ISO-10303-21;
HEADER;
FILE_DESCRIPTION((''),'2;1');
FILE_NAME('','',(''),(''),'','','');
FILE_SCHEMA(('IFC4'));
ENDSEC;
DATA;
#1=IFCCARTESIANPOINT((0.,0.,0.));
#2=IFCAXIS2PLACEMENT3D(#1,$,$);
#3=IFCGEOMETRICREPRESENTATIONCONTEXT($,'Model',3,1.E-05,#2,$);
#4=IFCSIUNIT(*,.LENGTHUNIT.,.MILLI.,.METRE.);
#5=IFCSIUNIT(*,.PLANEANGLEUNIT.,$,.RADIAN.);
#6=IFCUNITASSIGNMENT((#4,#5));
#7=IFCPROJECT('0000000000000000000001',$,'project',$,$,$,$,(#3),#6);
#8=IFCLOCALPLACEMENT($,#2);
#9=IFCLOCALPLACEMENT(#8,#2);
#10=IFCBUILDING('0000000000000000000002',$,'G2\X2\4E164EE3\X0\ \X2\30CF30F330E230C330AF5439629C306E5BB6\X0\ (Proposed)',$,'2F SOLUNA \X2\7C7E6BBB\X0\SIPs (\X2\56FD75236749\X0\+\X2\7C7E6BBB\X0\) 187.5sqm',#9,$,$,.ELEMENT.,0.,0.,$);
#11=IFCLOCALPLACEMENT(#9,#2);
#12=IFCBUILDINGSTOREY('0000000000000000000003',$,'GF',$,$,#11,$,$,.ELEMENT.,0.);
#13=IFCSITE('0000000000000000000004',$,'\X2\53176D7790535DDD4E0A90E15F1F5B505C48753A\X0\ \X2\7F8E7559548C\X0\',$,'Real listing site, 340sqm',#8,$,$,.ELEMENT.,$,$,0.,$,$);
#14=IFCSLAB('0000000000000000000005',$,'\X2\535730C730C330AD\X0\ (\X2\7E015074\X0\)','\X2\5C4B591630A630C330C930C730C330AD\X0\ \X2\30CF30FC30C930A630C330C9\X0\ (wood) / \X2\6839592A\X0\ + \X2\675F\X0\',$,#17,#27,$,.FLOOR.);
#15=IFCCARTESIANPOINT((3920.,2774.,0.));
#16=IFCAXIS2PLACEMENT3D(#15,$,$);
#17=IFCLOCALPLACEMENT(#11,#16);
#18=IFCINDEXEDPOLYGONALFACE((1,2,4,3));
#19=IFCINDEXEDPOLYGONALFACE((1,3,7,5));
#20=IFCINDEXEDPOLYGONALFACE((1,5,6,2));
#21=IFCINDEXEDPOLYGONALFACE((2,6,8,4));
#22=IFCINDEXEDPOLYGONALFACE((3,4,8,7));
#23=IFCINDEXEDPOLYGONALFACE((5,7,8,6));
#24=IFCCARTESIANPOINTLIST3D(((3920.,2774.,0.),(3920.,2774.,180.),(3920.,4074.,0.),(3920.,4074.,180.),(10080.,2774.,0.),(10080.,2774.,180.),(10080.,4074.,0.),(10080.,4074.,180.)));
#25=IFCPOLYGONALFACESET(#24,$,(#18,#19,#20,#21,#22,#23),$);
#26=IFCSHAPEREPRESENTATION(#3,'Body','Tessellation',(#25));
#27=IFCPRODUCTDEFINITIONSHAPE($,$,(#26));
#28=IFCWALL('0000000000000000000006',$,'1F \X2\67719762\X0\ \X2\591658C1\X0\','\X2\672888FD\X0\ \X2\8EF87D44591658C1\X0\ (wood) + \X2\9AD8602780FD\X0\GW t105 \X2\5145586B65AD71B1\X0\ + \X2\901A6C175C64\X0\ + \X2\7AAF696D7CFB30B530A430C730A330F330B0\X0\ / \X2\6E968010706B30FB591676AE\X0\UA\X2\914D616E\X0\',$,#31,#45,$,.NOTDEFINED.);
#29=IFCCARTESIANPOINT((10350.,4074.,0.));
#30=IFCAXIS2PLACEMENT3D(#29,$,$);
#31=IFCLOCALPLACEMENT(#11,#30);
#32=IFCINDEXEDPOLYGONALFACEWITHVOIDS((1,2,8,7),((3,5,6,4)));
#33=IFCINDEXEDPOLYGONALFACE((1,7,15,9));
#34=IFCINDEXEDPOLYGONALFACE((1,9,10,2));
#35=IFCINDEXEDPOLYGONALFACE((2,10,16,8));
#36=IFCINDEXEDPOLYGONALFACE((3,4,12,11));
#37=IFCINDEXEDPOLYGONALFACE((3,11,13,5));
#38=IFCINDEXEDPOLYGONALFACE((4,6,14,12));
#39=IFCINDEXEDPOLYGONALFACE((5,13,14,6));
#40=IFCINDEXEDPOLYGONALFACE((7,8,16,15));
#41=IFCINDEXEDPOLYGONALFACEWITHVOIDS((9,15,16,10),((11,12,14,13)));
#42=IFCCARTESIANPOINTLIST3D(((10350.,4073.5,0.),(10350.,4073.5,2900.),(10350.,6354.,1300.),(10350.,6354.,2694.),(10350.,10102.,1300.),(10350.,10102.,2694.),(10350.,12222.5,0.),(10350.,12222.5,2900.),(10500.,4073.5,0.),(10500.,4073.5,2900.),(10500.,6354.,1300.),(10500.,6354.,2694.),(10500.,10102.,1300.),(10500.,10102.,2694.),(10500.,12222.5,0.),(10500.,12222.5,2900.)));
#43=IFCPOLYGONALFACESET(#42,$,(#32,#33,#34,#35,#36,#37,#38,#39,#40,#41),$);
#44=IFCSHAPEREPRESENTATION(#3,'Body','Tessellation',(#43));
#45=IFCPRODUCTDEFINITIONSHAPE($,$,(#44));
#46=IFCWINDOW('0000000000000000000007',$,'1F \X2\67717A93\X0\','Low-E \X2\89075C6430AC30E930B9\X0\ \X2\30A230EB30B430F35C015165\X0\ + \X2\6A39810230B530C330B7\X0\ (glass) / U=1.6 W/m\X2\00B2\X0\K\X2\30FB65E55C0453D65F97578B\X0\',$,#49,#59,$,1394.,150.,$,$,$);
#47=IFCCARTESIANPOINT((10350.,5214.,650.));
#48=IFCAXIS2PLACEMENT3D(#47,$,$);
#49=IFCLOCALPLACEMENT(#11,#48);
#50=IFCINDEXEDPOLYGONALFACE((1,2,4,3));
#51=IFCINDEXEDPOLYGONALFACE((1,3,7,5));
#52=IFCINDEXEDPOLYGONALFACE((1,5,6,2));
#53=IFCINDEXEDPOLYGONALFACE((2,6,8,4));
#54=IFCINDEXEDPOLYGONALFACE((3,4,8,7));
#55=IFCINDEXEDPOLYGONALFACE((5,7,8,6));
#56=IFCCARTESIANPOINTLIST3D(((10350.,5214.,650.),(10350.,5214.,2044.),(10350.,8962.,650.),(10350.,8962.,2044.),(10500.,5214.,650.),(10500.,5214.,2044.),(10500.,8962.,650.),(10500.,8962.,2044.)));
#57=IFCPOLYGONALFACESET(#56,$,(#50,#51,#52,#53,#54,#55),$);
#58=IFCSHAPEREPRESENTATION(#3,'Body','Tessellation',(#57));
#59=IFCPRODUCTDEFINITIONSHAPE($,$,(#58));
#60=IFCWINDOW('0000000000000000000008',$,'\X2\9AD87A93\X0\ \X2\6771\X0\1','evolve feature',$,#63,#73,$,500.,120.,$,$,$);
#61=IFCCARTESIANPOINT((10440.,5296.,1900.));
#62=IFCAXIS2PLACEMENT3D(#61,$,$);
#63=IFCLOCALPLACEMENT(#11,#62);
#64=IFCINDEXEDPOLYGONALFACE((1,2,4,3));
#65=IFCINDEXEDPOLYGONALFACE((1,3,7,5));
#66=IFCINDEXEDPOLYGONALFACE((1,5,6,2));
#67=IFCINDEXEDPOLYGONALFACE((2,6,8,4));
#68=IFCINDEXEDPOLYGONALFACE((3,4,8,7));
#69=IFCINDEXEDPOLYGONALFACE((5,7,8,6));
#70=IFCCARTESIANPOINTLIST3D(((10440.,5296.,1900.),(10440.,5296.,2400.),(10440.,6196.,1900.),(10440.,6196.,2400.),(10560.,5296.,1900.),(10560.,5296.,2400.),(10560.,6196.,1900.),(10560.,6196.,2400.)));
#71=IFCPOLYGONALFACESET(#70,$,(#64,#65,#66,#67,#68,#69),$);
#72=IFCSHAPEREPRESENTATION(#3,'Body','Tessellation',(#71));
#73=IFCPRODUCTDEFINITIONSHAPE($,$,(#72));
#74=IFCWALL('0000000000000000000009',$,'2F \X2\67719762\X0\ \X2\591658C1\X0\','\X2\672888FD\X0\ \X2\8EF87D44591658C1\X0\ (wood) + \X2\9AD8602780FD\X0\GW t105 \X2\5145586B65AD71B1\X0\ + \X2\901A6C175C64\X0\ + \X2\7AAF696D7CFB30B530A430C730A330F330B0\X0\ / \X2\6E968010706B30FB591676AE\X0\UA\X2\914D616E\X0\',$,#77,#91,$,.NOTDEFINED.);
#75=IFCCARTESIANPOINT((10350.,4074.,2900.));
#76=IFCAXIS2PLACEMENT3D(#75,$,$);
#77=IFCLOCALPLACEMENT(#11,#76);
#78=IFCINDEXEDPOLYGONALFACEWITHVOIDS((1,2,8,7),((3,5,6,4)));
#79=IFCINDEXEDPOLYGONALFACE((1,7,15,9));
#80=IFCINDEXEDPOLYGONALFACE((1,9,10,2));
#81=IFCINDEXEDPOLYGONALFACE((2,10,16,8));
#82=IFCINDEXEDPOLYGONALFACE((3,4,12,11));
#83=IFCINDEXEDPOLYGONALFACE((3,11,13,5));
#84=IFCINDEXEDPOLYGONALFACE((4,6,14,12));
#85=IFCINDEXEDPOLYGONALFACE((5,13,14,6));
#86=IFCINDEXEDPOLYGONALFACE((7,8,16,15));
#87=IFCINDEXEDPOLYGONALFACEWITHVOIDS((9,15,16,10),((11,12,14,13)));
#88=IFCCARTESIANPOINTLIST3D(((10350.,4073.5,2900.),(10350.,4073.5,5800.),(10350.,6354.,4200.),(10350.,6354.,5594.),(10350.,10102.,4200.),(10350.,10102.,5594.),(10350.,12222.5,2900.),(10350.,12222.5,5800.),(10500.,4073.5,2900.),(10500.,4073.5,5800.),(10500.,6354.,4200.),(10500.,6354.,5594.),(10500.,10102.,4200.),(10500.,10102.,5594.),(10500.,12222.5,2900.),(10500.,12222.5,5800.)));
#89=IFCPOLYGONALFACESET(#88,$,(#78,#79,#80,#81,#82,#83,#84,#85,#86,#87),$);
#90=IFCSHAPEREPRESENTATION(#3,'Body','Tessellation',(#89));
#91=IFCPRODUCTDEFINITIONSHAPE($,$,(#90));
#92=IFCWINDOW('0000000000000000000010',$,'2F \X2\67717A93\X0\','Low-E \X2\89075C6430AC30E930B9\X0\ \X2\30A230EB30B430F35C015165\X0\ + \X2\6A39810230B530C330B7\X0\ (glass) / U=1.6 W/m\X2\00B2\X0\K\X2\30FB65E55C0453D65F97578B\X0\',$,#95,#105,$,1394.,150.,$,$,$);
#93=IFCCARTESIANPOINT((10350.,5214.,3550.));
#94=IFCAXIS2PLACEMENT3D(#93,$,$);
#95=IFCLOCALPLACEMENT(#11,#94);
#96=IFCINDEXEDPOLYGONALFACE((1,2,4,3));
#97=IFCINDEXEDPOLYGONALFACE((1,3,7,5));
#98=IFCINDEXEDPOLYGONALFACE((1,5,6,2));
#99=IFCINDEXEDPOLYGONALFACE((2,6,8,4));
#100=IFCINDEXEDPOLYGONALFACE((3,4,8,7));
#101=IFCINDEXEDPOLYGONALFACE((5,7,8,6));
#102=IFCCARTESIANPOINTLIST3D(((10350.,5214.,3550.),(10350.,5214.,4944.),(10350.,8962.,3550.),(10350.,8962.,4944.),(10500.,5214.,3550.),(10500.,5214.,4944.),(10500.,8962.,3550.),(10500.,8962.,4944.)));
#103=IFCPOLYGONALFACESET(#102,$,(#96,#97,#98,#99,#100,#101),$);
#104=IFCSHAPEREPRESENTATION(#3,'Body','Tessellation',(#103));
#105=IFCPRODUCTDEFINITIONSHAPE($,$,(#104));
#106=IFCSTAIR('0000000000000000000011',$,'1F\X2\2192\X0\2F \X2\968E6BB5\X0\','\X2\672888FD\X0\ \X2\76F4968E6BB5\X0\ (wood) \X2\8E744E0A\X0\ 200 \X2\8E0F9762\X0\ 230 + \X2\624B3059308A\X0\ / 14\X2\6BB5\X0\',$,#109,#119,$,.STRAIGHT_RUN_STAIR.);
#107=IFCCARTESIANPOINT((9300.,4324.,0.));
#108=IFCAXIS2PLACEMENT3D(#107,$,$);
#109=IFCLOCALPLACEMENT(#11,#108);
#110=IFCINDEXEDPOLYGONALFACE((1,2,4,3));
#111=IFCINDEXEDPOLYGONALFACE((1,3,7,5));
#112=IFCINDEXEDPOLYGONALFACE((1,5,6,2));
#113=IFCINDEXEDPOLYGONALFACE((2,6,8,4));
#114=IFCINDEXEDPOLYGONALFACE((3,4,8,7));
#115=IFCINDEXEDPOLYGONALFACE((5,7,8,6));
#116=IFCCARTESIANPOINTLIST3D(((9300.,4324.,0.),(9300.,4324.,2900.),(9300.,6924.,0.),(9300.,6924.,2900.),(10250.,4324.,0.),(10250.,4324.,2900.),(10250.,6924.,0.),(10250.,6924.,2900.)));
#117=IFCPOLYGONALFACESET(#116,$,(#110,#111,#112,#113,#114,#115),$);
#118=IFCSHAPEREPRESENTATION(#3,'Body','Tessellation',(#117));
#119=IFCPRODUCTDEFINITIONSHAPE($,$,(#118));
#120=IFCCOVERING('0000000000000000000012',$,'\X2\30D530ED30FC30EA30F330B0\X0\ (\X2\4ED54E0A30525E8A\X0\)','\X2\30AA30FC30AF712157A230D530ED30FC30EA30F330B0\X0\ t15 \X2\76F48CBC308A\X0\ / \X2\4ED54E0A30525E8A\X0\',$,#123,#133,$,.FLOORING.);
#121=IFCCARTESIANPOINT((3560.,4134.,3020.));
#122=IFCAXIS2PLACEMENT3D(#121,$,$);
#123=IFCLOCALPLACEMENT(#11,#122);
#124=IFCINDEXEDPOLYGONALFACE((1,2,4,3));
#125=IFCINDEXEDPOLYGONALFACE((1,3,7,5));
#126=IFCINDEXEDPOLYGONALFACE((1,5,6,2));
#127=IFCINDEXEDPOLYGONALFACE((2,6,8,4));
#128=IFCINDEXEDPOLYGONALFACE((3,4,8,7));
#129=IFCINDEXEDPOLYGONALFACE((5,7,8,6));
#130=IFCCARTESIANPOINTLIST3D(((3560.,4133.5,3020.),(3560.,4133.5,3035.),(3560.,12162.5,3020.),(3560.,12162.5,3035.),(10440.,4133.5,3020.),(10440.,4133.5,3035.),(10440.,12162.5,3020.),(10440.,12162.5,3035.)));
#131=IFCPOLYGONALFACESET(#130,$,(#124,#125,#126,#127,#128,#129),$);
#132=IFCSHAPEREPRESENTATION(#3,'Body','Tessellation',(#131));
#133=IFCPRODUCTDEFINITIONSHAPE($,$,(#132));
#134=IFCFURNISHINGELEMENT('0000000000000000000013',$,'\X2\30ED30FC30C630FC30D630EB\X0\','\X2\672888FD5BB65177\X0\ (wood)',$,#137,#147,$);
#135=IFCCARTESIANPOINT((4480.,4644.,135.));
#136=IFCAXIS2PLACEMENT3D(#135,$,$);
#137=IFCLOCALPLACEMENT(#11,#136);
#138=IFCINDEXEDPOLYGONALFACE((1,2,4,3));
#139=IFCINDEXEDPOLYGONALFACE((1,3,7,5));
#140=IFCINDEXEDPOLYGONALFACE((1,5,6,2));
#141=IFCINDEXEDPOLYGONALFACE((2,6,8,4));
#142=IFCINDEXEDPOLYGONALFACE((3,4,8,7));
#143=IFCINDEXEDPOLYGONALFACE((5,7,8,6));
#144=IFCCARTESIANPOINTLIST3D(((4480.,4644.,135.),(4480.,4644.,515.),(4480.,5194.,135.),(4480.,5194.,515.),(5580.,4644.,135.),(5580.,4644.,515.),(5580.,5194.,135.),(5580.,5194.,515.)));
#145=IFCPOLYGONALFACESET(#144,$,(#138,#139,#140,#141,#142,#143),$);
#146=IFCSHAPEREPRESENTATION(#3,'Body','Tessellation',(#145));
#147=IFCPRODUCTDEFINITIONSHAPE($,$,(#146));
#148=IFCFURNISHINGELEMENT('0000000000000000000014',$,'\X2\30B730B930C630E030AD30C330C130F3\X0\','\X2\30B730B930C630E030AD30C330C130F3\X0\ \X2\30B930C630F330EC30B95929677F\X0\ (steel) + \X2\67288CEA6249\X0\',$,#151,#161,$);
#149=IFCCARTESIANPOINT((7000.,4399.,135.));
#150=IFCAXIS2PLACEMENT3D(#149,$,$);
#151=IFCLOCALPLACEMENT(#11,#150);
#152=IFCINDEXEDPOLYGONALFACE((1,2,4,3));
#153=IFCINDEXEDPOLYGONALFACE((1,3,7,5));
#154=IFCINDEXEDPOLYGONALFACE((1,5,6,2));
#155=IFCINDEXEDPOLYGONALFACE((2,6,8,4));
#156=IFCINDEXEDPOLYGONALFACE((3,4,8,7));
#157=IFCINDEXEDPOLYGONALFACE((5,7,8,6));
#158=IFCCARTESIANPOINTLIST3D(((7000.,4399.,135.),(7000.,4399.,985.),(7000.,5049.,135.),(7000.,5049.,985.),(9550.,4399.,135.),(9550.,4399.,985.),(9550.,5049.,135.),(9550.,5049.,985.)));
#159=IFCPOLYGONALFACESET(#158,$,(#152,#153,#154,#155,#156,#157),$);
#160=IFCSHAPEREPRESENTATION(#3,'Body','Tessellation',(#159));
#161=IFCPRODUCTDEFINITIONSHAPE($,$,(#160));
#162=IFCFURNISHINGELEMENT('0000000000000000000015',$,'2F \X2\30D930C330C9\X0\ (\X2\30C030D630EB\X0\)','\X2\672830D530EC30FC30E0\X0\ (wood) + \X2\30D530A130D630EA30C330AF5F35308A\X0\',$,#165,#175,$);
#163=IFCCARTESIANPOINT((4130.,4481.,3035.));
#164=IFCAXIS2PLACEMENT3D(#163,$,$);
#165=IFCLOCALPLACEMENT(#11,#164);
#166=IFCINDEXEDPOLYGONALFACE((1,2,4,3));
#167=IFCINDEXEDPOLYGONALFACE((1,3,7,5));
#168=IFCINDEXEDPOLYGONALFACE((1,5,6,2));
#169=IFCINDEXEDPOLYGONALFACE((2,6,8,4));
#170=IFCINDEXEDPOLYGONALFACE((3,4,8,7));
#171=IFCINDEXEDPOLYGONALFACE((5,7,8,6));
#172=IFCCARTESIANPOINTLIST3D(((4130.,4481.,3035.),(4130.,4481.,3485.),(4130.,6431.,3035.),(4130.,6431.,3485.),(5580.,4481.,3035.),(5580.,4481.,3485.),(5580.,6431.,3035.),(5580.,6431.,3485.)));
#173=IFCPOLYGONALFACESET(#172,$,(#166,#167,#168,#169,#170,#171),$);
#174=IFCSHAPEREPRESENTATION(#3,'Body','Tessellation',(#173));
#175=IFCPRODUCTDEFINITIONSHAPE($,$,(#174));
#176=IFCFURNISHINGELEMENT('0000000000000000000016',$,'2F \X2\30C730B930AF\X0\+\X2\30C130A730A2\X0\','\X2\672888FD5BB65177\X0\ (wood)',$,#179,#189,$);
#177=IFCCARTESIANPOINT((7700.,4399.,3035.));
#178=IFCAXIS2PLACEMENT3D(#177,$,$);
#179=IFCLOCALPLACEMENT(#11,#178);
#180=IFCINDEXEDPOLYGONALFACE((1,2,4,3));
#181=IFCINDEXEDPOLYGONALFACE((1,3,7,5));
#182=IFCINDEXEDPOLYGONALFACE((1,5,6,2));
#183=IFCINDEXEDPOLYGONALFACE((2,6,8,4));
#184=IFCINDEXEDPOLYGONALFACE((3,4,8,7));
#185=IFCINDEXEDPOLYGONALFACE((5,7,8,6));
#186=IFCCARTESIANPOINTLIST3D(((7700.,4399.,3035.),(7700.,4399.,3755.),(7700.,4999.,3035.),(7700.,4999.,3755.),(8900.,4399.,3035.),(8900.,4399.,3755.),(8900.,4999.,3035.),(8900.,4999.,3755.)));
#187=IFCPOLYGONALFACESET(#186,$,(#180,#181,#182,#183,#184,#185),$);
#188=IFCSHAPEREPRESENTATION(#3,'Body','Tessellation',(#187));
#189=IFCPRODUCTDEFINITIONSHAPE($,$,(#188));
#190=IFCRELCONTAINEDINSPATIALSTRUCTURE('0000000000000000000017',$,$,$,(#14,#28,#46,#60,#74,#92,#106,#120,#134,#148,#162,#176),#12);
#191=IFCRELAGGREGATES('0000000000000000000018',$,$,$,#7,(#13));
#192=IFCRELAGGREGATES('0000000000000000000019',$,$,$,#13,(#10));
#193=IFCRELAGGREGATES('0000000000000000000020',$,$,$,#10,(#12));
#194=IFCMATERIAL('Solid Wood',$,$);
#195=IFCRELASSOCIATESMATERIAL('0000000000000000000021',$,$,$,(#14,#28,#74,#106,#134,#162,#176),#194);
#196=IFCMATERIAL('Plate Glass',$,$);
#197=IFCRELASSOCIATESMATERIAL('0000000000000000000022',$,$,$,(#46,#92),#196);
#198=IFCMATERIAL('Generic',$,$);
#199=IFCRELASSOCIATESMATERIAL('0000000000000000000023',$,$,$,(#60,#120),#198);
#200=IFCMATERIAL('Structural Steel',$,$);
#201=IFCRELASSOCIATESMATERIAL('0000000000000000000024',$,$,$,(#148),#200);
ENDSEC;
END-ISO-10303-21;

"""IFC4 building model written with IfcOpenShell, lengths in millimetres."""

from ifc_helpers import new_model, si_unit, frame, frame_2d, origin, place, context, project, spatial, rectangle, extrude, material, element, fill, save


model = new_model("IFC4")

# Units and contexts
model_context = context("Model", 3, precision=1e-05, world=origin())
ifc_project = project(units=[si_unit("LENGTHUNIT", "METRE", prefix="MILLI"), si_unit("PLANEANGLEUNIT", "RADIAN")], contexts=[model_context])

# Site, building, storey
site_placement = place(None, origin())
site = spatial("IfcSite", under=ifc_project, at=site_placement, Name="北海道川上郡弟子屈町 美留和", ObjectType="Real listing site, 340sqm", CompositionType="ELEMENT", RefElevation=0.0)
building_placement = place(site_placement, origin())
building = spatial("IfcBuilding", under=site, at=building_placement, Name="G2世代 ハンモック吹抜の家 (Proposed)", ObjectType="2F SOLUNA 籾殻SIPs (国産杉+籾殻) 187.5sqm", CompositionType="ELEMENT", ElevationOfRefHeight=0.0, ElevationOfTerrain=0.0)
storey_placement = place(building_placement, origin())
storey = spatial("IfcBuildingStorey", under=building, at=storey_placement, Name="GF", CompositionType="ELEMENT", Elevation=0.0)

# Slab
ifc_material_1 = material(Name="Solid Wood")
slab_placement = place(storey_placement, frame((3920.0, 2774.0, 0.0)))
element("IfcSlab", 1, at=slab_placement, inside=storey, material=ifc_material_1, Name="南デッキ (縁側)", Description="屋外ウッドデッキ ハードウッド (wood) / 根太 + 束", PredefinedType="FLOOR", context=model_context, shape_type="SweptSolid", body=[
    extrude(rectangle(XDim=6160.0, YDim=1300.0, at=frame_2d((3080.0, 650.0))), frame((3920.0, 2774.0, 0.0)), (0.0, 0.0, 1.0), 180.0),
])

# Wall, openings, windows
wall_1_placement = place(storey_placement, frame((10350.0, 4074.0, 0.0)))
wall_1 = element("IfcWall", 2, at=wall_1_placement, inside=storey, material=ifc_material_1, Name="1F 東面 外壁", Description="木製 軸組外壁 (wood) + 高性能GW t105 充填断熱 + 通気層 + 窯業系サイディング / 準耐火・外皮UA配慮", PredefinedType="NOTDEFINED", context=model_context, shape_type="SweptSolid", body=[
    extrude(rectangle(XDim=150.0, YDim=8149.0, at=frame_2d((75.0, 4074.0))), frame((10350.0, 4074.0, 0.0)), (0.0, 0.0, 1.0), 2900.0),
])
opening_1_placement = place(storey_placement, frame((10350.0, 5214.0, 650.0)))
opening_1 = element("IfcOpeningElement", 3, at=opening_1_placement, cuts=wall_1, PredefinedType="NOTDEFINED", context=model_context, shape_type="SweptSolid", body=[
    extrude(rectangle(XDim=150.0, YDim=3748.0, at=frame_2d((75.0, 1874.0))), frame((10350.0, 5214.0, 650.0)), (0.0, 0.0, 1.0), 1394.0),
])
opening_2_placement = place(storey_placement, frame((10440.0, 5296.0, 1900.0)))
opening_2 = element("IfcOpeningElement", 4, at=opening_2_placement, cuts=wall_1, PredefinedType="NOTDEFINED", context=model_context, shape_type="SweptSolid", body=[
    extrude(rectangle(XDim=120.0, YDim=900.0, at=frame_2d((60.0, 450.0))), frame((10440.0, 5296.0, 1900.0)), (0.0, 0.0, 1.0), 500.0),
])
ifc_material_2 = material(Name="Plate Glass")
window_1_placement = place(storey_placement, frame((10350.0, 5214.0, 650.0)))
window_1 = element("IfcWindow", 5, at=window_1_placement, inside=storey, material=ifc_material_2, Name="1F 東窓", Description="Low-E 複層ガラス アルゴン封入 + 樹脂サッシ (glass) / U=1.6 W/m²K・日射取得型", OverallHeight=1394.0, OverallWidth=150.0, context=model_context, shape_type="SweptSolid", body=[
    extrude(rectangle(XDim=150.0, YDim=3748.0, at=frame_2d((75.0, 1874.0))), frame((10350.0, 5214.0, 650.0)), (0.0, 0.0, 1.0), 1394.0),
])
fill(opening_1, window_1)
ifc_material_3 = material(Name="Generic")
window_2_placement = place(storey_placement, frame((10440.0, 5296.0, 1900.0)))
window_2 = element("IfcWindow", 6, at=window_2_placement, inside=storey, material=ifc_material_3, Name="高窓 東1", Description="evolve feature", OverallHeight=500.0, OverallWidth=120.0, context=model_context, shape_type="SweptSolid", body=[
    extrude(rectangle(XDim=120.0, YDim=900.0, at=frame_2d((60.0, 450.0))), frame((10440.0, 5296.0, 1900.0)), (0.0, 0.0, 1.0), 500.0),
])
fill(opening_2, window_2)

# Wall, opening, window
wall_2_placement = place(storey_placement, frame((10350.0, 4074.0, 2900.0)))
wall_2 = element("IfcWall", 7, at=wall_2_placement, inside=storey, material=ifc_material_1, Name="2F 東面 外壁", Description="木製 軸組外壁 (wood) + 高性能GW t105 充填断熱 + 通気層 + 窯業系サイディング / 準耐火・外皮UA配慮", PredefinedType="NOTDEFINED", context=model_context, shape_type="SweptSolid", body=[
    extrude(rectangle(XDim=150.0, YDim=8149.0, at=frame_2d((75.0, 4074.0))), frame((10350.0, 4074.0, 2900.0)), (0.0, 0.0, 1.0), 2900.0),
])
opening_3_placement = place(storey_placement, frame((10350.0, 5214.0, 3550.0)))
opening_3 = element("IfcOpeningElement", 8, at=opening_3_placement, cuts=wall_2, PredefinedType="NOTDEFINED", context=model_context, shape_type="SweptSolid", body=[
    extrude(rectangle(XDim=150.0, YDim=3748.0, at=frame_2d((75.0, 1874.0))), frame((10350.0, 5214.0, 3550.0)), (0.0, 0.0, 1.0), 1394.0),
])
window_3_placement = place(storey_placement, frame((10350.0, 5214.0, 3550.0)))
window_3 = element("IfcWindow", 9, at=window_3_placement, inside=storey, material=ifc_material_2, Name="2F 東窓", Description="Low-E 複層ガラス アルゴン封入 + 樹脂サッシ (glass) / U=1.6 W/m²K・日射取得型", OverallHeight=1394.0, OverallWidth=150.0, context=model_context, shape_type="SweptSolid", body=[
    extrude(rectangle(XDim=150.0, YDim=3748.0, at=frame_2d((75.0, 1874.0))), frame((10350.0, 5214.0, 3550.0)), (0.0, 0.0, 1.0), 1394.0),
])
fill(opening_3, window_3)

# Stair
stair_placement = place(storey_placement, frame((9300.0, 4324.0, 0.0)))
element("IfcStair", 10, at=stair_placement, inside=storey, material=ifc_material_1, Name="1F→2F 階段", Description="木製 直階段 (wood) 蹴上 200 踏面 230 + 手すり / 14段", PredefinedType="STRAIGHT_RUN_STAIR", context=model_context, shape_type="SweptSolid", body=[
    extrude(rectangle(XDim=950.0, YDim=2600.0, at=frame_2d((475.0, 1300.0))), frame((9300.0, 4324.0, 0.0)), (0.0, 0.0, 1.0), 2900.0),
])

# Covering
covering_placement = place(storey_placement, frame((3560.0, 4134.0, 3020.0)))
element("IfcCovering", 11, at=covering_placement, inside=storey, material=ifc_material_3, Name="フローリング (仕上げ床)", Description="オーク無垢フローリング t15 直貼り / 仕上げ床", PredefinedType="FLOORING", context=model_context, shape_type="SweptSolid", body=[
    extrude(rectangle(XDim=6880.0, YDim=8029.0, at=frame_2d((3440.0, 4014.0))), frame((3560.0, 4134.0, 3020.0)), (0.0, 0.0, 1.0), 15.0),
])

# Furnishing elements
furnishing_1_placement = place(storey_placement, frame((4480.0, 4644.0, 135.0)))
element("IfcFurnishingElement", 12, at=furnishing_1_placement, inside=storey, material=ifc_material_1, Name="ローテーブル", Description="木製家具 (wood)", context=model_context, shape_type="SweptSolid", body=[
    extrude(rectangle(XDim=1100.0, YDim=550.0, at=frame_2d((550.0, 275.0))), frame((4480.0, 4644.0, 135.0)), (0.0, 0.0, 1.0), 380.0),
])
ifc_material_4 = material(Name="Structural Steel")
furnishing_2_placement = place(storey_placement, frame((7000.0, 4399.0, 135.0)))
element("IfcFurnishingElement", 13, at=furnishing_2_placement, inside=storey, material=ifc_material_4, Name="システムキッチン", Description="システムキッチン ステンレス天板 (steel) + 木質扉", context=model_context, shape_type="SweptSolid", body=[
    extrude(rectangle(XDim=2550.0, YDim=650.0, at=frame_2d((1275.0, 325.0))), frame((7000.0, 4399.0, 135.0)), (0.0, 0.0, 1.0), 850.0),
])
furnishing_3_placement = place(storey_placement, frame((4130.0, 4481.0, 3035.0)))
element("IfcFurnishingElement", 14, at=furnishing_3_placement, inside=storey, material=ifc_material_1, Name="2F ベッド (ダブル)", Description="木フレーム (wood) + ファブリック張り", context=model_context, shape_type="SweptSolid", body=[
    extrude(rectangle(XDim=1450.0, YDim=1950.0, at=frame_2d((725.0, 975.0))), frame((4130.0, 4481.0, 3035.0)), (0.0, 0.0, 1.0), 450.0),
])
furnishing_4_placement = place(storey_placement, frame((7700.0, 4399.0, 3035.0)))
element("IfcFurnishingElement", 15, at=furnishing_4_placement, inside=storey, material=ifc_material_1, Name="2F デスク+チェア", Description="木製家具 (wood)", context=model_context, shape_type="SweptSolid", body=[
    extrude(rectangle(XDim=1200.0, YDim=600.0, at=frame_2d((600.0, 300.0))), frame((7700.0, 4399.0, 3035.0)), (0.0, 0.0, 1.0), 720.0),
])

save(model, "model.ifc")
